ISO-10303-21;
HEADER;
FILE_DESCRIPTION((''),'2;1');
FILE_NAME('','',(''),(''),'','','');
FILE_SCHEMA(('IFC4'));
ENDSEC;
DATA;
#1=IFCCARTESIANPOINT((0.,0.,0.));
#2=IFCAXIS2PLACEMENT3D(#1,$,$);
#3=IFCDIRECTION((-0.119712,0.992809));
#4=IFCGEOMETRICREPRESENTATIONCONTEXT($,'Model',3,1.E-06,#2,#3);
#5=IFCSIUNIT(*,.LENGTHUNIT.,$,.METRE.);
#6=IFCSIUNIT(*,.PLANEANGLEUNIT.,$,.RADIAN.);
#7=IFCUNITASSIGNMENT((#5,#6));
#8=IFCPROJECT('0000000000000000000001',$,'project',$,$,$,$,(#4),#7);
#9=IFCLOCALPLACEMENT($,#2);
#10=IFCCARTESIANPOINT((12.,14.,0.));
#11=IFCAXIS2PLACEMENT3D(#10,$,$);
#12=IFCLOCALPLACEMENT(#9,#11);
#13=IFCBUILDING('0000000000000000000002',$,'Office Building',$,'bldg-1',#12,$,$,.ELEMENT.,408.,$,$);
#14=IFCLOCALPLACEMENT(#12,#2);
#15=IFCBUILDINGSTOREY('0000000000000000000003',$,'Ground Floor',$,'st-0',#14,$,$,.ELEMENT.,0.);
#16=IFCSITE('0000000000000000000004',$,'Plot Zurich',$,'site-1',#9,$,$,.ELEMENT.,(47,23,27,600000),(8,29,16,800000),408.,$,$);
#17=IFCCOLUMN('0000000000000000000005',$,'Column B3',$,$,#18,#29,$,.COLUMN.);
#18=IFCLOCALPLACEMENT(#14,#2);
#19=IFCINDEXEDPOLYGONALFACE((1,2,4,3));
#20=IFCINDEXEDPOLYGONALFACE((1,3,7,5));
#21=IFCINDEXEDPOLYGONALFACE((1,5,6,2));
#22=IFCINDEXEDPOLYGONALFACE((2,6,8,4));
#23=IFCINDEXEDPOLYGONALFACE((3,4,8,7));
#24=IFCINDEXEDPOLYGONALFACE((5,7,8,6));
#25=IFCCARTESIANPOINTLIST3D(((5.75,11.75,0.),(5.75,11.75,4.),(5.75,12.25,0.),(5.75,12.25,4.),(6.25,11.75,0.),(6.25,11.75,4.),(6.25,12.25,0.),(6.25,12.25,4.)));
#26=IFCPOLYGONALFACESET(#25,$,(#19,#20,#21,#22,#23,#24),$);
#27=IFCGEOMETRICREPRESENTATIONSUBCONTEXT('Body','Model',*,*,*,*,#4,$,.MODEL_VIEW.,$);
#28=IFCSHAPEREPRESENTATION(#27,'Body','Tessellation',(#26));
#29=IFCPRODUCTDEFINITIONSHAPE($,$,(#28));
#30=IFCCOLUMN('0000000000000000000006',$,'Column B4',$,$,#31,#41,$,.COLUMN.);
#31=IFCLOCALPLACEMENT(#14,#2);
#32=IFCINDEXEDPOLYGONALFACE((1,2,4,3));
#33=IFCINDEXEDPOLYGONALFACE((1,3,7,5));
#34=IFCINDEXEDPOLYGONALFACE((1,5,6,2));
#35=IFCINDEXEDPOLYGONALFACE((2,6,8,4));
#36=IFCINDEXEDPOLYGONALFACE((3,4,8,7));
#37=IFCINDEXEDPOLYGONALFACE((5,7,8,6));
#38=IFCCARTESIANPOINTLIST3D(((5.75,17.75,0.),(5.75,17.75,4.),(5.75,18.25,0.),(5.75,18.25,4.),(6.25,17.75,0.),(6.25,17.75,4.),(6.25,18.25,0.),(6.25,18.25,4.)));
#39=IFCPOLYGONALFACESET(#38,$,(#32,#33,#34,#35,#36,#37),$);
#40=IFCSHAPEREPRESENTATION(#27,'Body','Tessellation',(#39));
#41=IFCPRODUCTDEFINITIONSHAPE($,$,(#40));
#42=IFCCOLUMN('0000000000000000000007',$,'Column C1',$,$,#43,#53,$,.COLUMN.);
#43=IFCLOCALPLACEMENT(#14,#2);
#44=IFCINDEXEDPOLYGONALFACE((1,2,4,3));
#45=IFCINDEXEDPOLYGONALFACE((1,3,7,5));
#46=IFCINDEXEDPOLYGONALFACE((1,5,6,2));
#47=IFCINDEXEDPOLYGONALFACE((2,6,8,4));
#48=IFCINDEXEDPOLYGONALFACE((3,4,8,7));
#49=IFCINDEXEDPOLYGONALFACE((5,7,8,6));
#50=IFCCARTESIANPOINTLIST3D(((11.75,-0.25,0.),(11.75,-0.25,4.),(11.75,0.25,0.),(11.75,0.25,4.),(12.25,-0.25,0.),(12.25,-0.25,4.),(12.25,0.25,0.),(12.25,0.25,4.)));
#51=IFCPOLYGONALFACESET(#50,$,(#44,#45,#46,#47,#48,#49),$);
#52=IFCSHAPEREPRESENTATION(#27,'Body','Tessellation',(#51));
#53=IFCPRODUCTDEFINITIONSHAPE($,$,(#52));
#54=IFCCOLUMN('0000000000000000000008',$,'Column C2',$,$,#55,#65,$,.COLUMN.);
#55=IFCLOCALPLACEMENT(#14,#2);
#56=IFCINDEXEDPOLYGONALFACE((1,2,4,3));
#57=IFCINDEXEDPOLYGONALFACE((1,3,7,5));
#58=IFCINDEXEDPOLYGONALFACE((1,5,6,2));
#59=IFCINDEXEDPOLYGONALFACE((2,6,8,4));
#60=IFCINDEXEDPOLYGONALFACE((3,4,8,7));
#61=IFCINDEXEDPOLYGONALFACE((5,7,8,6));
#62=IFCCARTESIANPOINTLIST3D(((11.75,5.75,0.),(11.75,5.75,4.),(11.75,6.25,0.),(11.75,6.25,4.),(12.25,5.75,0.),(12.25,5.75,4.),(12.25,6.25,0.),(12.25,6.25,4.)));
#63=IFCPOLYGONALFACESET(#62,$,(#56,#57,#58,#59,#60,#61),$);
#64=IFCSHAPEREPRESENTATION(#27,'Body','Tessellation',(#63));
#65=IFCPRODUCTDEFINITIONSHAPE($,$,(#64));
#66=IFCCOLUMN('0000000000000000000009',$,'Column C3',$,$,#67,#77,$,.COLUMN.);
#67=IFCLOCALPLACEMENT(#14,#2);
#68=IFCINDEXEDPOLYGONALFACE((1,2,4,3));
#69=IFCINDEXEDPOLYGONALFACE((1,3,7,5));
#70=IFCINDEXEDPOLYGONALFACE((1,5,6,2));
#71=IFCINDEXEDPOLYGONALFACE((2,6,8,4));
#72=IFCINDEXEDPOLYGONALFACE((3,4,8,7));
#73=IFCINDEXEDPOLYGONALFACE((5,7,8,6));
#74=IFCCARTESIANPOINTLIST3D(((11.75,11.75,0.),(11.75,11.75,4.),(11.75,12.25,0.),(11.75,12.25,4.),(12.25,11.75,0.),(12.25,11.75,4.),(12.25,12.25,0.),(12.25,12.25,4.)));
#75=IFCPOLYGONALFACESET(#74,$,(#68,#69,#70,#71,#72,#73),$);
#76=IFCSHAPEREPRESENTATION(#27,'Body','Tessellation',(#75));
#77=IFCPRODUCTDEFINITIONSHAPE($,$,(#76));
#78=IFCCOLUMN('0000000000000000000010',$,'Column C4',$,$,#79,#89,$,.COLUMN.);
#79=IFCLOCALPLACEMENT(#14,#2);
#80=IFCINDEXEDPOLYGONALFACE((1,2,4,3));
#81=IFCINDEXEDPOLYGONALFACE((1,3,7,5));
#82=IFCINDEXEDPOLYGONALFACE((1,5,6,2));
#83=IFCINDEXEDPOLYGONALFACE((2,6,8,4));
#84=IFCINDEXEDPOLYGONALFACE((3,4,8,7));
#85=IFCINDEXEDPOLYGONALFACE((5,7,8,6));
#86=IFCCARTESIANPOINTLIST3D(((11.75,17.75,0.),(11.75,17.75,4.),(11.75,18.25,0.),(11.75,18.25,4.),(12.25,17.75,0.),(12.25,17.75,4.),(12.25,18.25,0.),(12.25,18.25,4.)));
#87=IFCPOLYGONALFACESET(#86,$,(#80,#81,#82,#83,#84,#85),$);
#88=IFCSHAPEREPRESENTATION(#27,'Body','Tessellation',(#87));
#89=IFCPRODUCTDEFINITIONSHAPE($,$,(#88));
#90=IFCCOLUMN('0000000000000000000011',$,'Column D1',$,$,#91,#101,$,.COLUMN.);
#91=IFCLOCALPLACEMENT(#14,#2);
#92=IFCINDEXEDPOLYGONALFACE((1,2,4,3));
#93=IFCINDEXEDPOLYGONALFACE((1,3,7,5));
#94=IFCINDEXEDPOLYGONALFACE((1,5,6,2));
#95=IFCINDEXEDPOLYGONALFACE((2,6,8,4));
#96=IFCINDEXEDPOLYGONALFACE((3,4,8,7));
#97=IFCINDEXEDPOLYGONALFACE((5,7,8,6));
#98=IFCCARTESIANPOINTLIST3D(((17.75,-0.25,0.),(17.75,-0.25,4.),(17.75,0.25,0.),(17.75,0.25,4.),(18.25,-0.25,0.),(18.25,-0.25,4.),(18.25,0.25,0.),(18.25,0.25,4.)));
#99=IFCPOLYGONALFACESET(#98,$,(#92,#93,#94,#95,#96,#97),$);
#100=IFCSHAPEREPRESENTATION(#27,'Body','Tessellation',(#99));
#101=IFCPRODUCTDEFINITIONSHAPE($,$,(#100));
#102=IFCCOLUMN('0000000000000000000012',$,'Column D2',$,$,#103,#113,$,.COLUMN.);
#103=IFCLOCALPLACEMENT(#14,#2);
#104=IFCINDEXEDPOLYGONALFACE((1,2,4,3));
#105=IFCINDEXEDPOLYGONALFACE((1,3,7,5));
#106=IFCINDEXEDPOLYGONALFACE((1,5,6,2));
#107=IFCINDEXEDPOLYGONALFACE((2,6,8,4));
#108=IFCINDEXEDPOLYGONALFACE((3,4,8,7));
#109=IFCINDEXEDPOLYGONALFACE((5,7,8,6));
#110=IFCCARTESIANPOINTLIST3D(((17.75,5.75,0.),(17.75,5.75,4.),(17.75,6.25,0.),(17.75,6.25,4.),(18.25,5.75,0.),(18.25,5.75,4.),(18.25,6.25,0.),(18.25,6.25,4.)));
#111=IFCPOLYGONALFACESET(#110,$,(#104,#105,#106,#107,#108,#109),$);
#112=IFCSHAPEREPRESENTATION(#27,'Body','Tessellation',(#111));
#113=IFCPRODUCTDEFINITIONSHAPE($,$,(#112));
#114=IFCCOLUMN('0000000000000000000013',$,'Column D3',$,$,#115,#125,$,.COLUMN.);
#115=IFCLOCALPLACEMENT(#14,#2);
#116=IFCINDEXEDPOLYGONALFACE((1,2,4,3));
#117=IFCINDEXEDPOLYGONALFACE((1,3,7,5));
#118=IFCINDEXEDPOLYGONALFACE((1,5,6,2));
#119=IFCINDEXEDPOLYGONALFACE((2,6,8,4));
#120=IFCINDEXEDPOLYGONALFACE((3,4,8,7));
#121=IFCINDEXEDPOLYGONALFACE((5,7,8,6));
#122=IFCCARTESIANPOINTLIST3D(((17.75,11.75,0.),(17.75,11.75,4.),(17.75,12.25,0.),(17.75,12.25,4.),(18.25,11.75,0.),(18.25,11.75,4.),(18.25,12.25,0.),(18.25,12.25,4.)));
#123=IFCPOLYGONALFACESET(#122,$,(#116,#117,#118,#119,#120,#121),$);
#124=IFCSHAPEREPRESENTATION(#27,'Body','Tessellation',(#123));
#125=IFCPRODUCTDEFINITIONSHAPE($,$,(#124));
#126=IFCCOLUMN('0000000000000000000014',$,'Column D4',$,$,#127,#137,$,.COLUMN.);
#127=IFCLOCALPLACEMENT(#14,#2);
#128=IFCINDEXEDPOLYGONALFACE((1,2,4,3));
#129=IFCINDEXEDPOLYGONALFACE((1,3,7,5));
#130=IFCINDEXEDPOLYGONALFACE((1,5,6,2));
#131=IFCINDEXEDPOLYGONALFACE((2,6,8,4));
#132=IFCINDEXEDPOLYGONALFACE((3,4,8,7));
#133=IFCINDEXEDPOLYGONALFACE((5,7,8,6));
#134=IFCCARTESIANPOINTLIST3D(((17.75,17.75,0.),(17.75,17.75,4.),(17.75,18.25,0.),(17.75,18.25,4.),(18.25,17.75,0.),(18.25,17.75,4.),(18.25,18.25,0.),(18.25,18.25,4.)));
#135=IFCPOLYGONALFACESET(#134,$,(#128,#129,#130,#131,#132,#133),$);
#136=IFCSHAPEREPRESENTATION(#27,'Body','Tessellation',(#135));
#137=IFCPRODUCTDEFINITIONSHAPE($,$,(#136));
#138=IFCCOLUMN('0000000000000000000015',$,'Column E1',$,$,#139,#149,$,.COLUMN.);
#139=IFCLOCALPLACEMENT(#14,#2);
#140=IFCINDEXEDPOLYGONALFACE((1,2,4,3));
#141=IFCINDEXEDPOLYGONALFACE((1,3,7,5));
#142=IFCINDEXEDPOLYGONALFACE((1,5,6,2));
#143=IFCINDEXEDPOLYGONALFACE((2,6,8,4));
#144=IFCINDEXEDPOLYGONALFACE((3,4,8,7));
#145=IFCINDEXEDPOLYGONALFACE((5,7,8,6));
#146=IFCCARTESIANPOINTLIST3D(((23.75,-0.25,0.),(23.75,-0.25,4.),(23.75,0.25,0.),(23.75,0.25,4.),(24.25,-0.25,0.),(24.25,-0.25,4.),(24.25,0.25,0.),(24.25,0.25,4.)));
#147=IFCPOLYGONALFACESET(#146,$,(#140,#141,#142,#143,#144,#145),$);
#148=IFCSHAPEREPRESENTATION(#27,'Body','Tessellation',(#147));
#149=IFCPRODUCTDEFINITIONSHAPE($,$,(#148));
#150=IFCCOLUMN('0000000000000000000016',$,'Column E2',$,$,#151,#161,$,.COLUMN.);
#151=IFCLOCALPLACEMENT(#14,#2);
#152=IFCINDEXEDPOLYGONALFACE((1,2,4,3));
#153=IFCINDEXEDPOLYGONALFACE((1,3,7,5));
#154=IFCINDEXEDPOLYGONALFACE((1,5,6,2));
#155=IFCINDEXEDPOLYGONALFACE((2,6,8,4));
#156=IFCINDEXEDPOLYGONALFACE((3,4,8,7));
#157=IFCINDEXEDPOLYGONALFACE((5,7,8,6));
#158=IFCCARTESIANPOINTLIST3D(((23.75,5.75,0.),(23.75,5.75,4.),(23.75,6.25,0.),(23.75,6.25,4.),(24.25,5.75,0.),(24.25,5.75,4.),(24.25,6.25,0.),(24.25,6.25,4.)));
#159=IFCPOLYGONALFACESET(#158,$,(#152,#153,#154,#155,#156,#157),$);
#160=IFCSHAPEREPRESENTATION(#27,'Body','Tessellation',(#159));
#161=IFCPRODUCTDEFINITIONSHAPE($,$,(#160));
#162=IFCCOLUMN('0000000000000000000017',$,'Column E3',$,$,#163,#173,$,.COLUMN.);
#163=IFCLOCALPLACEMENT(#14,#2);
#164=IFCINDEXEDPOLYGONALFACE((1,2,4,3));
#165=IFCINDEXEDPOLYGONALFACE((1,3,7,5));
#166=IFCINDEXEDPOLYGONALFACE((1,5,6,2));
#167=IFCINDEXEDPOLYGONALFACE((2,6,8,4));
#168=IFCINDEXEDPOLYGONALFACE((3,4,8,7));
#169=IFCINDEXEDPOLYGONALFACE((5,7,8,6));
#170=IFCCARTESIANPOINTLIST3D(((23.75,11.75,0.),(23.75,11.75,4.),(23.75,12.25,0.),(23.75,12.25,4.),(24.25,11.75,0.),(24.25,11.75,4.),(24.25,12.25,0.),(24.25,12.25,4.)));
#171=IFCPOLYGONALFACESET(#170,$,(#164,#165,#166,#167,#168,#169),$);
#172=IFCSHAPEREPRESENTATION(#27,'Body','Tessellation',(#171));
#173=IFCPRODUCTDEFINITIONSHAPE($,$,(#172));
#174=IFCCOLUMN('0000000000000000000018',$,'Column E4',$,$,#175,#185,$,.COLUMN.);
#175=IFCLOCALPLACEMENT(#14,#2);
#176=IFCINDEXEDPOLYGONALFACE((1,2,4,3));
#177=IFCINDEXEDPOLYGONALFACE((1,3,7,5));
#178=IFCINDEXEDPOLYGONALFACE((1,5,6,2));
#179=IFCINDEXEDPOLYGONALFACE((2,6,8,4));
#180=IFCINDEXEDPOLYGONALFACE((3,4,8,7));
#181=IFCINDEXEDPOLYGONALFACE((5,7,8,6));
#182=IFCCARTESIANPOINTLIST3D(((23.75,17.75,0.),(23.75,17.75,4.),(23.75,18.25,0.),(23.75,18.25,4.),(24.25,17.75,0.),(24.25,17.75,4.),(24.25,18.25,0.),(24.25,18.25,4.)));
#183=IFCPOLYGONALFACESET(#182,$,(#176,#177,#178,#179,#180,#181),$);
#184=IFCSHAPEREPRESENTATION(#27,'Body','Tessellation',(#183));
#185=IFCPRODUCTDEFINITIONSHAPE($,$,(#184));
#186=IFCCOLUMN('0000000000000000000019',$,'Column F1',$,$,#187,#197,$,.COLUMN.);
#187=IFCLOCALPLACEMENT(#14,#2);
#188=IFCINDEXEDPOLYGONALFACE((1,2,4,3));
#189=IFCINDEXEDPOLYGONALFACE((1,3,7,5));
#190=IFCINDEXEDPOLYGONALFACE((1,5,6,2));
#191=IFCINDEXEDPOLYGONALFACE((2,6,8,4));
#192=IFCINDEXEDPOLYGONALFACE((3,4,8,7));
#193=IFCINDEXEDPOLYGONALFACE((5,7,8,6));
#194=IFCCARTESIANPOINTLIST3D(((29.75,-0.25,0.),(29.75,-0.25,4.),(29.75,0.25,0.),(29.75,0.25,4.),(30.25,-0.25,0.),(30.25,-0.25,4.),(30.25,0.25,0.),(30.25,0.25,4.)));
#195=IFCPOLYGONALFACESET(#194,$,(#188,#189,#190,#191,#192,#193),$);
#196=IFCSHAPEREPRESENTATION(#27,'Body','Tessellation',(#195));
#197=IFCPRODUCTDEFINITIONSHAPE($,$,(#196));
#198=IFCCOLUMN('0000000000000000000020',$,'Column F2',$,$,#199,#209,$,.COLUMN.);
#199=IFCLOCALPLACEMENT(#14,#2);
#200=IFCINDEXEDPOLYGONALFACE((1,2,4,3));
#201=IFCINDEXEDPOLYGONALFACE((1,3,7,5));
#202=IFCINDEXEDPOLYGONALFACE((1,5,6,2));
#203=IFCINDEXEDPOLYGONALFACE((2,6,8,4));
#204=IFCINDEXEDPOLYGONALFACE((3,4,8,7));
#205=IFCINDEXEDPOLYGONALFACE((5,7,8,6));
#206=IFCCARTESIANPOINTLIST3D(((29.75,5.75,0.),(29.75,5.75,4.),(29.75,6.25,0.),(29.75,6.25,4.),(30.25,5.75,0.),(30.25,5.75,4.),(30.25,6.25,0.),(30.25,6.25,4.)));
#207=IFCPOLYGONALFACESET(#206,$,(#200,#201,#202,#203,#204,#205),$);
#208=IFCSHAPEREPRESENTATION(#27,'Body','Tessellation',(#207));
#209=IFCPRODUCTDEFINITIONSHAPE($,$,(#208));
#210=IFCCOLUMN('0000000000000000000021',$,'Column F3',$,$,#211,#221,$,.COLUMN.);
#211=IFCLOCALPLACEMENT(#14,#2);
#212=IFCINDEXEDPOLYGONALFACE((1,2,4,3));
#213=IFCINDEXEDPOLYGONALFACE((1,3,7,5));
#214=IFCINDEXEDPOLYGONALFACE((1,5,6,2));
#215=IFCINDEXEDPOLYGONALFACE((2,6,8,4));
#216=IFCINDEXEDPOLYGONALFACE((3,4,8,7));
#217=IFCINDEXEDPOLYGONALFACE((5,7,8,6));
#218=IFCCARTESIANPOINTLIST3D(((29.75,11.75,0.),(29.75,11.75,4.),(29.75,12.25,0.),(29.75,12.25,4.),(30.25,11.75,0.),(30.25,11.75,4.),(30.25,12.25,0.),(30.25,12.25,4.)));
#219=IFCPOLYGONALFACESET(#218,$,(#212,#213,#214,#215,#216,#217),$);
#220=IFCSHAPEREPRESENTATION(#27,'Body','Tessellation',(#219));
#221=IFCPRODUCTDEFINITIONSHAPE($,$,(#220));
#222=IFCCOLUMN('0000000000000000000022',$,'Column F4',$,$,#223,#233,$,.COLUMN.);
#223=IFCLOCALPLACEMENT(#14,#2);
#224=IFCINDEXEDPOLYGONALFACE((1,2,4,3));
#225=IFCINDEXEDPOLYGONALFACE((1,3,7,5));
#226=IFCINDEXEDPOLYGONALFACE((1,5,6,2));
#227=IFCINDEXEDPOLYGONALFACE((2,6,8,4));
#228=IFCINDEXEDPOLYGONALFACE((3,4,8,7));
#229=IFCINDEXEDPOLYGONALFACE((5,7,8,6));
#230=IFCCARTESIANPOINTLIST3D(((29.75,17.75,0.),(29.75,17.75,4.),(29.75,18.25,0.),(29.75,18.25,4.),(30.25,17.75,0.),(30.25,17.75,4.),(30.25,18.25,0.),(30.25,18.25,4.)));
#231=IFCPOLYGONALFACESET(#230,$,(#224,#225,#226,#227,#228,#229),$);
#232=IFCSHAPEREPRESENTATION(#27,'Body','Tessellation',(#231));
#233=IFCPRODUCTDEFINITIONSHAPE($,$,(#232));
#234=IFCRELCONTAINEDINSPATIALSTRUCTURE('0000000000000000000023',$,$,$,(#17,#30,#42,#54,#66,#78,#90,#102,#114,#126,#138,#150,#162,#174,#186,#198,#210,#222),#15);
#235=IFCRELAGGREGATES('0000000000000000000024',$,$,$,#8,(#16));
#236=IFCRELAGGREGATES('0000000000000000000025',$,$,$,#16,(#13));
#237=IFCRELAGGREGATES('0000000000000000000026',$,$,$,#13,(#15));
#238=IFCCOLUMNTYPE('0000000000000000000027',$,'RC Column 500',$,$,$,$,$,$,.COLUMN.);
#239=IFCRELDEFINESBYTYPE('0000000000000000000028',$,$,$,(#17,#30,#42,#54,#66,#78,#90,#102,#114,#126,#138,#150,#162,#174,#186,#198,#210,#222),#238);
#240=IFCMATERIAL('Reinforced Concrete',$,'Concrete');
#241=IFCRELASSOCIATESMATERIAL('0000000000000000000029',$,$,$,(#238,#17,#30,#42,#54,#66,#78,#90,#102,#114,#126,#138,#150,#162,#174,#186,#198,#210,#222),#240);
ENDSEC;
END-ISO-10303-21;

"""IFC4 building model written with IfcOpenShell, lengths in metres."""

from ifc_helpers import new_model, si_unit, direction, frame, origin, origin_2d, place, context, subcontext, project, spatial, rectangle, extrude, material, type_object, element, save


model = new_model("IFC4")

# Units and contexts
model_context = context("Model", 3, precision=1e-06, world=origin(), true_north=direction((-0.119712, 0.992809)))
body_context = subcontext(model_context, "Body", "Model", "MODEL_VIEW")
ifc_project = project(units=[si_unit("LENGTHUNIT", "METRE"), si_unit("PLANEANGLEUNIT", "RADIAN")], contexts=[model_context])

# Site, building, storey
site_placement = place(None, origin())
site = spatial("IfcSite", under=ifc_project, at=site_placement, Name="Plot Zurich", ObjectType="site-1", CompositionType="ELEMENT", RefLatitude=(47, 23, 27, 600000), RefLongitude=(8, 29, 16, 800000), RefElevation=408.0)
building_placement = place(site_placement, frame((12.0, 14.0, 0.0)))
building = spatial("IfcBuilding", under=site, at=building_placement, Name="Office Building", ObjectType="bldg-1", CompositionType="ELEMENT", ElevationOfRefHeight=408.0)
storey_placement = place(building_placement, origin())
storey = spatial("IfcBuildingStorey", under=building, at=storey_placement, Name="Ground Floor", ObjectType="st-0", CompositionType="ELEMENT", Elevation=0.0)

# Columns
ifc_material_1 = material(Name="Reinforced Concrete", Category="Concrete")
column_type = type_object("IfcColumnType", Name="RC Column 500", PredefinedType="COLUMN", material=ifc_material_1)
for number, where, name in (
    (1, (6.0, 12.0, 0.0), "Column B3"),
    (2, (6.0, 18.0, 0.0), "Column B4"),
    (3, (12.0, 0.0, 0.0), "Column C1"),
    (4, (12.0, 6.0, 0.0), "Column C2"),
    (5, (12.0, 12.0, 0.0), "Column C3"),
    (6, (12.0, 18.0, 0.0), "Column C4"),
    (7, (18.0, 0.0, 0.0), "Column D1"),
    (8, (18.0, 6.0, 0.0), "Column D2"),
    (9, (18.0, 12.0, 0.0), "Column D3"),
    (10, (18.0, 18.0, 0.0), "Column D4"),
    (11, (24.0, 0.0, 0.0), "Column E1"),
    (12, (24.0, 6.0, 0.0), "Column E2"),
    (13, (24.0, 12.0, 0.0), "Column E3"),
    (14, (24.0, 18.0, 0.0), "Column E4"),
    (15, (30.0, 0.0, 0.0), "Column F1"),
    (16, (30.0, 6.0, 0.0), "Column F2"),
    (17, (30.0, 12.0, 0.0), "Column F3"),
    (18, (30.0, 18.0, 0.0), "Column F4"),
):
    element("IfcColumn", number, at=place(storey_placement, frame(where)), inside=storey, type_object=column_type, material=ifc_material_1, Name=name, PredefinedType="COLUMN", context=body_context, shape_type="SweptSolid", body=[
        extrude(rectangle(XDim=0.5, YDim=0.5, at=origin_2d()), origin(), (0.0, 0.0, 1.0), 4.0),
    ])

save(model, "model.ifc")
